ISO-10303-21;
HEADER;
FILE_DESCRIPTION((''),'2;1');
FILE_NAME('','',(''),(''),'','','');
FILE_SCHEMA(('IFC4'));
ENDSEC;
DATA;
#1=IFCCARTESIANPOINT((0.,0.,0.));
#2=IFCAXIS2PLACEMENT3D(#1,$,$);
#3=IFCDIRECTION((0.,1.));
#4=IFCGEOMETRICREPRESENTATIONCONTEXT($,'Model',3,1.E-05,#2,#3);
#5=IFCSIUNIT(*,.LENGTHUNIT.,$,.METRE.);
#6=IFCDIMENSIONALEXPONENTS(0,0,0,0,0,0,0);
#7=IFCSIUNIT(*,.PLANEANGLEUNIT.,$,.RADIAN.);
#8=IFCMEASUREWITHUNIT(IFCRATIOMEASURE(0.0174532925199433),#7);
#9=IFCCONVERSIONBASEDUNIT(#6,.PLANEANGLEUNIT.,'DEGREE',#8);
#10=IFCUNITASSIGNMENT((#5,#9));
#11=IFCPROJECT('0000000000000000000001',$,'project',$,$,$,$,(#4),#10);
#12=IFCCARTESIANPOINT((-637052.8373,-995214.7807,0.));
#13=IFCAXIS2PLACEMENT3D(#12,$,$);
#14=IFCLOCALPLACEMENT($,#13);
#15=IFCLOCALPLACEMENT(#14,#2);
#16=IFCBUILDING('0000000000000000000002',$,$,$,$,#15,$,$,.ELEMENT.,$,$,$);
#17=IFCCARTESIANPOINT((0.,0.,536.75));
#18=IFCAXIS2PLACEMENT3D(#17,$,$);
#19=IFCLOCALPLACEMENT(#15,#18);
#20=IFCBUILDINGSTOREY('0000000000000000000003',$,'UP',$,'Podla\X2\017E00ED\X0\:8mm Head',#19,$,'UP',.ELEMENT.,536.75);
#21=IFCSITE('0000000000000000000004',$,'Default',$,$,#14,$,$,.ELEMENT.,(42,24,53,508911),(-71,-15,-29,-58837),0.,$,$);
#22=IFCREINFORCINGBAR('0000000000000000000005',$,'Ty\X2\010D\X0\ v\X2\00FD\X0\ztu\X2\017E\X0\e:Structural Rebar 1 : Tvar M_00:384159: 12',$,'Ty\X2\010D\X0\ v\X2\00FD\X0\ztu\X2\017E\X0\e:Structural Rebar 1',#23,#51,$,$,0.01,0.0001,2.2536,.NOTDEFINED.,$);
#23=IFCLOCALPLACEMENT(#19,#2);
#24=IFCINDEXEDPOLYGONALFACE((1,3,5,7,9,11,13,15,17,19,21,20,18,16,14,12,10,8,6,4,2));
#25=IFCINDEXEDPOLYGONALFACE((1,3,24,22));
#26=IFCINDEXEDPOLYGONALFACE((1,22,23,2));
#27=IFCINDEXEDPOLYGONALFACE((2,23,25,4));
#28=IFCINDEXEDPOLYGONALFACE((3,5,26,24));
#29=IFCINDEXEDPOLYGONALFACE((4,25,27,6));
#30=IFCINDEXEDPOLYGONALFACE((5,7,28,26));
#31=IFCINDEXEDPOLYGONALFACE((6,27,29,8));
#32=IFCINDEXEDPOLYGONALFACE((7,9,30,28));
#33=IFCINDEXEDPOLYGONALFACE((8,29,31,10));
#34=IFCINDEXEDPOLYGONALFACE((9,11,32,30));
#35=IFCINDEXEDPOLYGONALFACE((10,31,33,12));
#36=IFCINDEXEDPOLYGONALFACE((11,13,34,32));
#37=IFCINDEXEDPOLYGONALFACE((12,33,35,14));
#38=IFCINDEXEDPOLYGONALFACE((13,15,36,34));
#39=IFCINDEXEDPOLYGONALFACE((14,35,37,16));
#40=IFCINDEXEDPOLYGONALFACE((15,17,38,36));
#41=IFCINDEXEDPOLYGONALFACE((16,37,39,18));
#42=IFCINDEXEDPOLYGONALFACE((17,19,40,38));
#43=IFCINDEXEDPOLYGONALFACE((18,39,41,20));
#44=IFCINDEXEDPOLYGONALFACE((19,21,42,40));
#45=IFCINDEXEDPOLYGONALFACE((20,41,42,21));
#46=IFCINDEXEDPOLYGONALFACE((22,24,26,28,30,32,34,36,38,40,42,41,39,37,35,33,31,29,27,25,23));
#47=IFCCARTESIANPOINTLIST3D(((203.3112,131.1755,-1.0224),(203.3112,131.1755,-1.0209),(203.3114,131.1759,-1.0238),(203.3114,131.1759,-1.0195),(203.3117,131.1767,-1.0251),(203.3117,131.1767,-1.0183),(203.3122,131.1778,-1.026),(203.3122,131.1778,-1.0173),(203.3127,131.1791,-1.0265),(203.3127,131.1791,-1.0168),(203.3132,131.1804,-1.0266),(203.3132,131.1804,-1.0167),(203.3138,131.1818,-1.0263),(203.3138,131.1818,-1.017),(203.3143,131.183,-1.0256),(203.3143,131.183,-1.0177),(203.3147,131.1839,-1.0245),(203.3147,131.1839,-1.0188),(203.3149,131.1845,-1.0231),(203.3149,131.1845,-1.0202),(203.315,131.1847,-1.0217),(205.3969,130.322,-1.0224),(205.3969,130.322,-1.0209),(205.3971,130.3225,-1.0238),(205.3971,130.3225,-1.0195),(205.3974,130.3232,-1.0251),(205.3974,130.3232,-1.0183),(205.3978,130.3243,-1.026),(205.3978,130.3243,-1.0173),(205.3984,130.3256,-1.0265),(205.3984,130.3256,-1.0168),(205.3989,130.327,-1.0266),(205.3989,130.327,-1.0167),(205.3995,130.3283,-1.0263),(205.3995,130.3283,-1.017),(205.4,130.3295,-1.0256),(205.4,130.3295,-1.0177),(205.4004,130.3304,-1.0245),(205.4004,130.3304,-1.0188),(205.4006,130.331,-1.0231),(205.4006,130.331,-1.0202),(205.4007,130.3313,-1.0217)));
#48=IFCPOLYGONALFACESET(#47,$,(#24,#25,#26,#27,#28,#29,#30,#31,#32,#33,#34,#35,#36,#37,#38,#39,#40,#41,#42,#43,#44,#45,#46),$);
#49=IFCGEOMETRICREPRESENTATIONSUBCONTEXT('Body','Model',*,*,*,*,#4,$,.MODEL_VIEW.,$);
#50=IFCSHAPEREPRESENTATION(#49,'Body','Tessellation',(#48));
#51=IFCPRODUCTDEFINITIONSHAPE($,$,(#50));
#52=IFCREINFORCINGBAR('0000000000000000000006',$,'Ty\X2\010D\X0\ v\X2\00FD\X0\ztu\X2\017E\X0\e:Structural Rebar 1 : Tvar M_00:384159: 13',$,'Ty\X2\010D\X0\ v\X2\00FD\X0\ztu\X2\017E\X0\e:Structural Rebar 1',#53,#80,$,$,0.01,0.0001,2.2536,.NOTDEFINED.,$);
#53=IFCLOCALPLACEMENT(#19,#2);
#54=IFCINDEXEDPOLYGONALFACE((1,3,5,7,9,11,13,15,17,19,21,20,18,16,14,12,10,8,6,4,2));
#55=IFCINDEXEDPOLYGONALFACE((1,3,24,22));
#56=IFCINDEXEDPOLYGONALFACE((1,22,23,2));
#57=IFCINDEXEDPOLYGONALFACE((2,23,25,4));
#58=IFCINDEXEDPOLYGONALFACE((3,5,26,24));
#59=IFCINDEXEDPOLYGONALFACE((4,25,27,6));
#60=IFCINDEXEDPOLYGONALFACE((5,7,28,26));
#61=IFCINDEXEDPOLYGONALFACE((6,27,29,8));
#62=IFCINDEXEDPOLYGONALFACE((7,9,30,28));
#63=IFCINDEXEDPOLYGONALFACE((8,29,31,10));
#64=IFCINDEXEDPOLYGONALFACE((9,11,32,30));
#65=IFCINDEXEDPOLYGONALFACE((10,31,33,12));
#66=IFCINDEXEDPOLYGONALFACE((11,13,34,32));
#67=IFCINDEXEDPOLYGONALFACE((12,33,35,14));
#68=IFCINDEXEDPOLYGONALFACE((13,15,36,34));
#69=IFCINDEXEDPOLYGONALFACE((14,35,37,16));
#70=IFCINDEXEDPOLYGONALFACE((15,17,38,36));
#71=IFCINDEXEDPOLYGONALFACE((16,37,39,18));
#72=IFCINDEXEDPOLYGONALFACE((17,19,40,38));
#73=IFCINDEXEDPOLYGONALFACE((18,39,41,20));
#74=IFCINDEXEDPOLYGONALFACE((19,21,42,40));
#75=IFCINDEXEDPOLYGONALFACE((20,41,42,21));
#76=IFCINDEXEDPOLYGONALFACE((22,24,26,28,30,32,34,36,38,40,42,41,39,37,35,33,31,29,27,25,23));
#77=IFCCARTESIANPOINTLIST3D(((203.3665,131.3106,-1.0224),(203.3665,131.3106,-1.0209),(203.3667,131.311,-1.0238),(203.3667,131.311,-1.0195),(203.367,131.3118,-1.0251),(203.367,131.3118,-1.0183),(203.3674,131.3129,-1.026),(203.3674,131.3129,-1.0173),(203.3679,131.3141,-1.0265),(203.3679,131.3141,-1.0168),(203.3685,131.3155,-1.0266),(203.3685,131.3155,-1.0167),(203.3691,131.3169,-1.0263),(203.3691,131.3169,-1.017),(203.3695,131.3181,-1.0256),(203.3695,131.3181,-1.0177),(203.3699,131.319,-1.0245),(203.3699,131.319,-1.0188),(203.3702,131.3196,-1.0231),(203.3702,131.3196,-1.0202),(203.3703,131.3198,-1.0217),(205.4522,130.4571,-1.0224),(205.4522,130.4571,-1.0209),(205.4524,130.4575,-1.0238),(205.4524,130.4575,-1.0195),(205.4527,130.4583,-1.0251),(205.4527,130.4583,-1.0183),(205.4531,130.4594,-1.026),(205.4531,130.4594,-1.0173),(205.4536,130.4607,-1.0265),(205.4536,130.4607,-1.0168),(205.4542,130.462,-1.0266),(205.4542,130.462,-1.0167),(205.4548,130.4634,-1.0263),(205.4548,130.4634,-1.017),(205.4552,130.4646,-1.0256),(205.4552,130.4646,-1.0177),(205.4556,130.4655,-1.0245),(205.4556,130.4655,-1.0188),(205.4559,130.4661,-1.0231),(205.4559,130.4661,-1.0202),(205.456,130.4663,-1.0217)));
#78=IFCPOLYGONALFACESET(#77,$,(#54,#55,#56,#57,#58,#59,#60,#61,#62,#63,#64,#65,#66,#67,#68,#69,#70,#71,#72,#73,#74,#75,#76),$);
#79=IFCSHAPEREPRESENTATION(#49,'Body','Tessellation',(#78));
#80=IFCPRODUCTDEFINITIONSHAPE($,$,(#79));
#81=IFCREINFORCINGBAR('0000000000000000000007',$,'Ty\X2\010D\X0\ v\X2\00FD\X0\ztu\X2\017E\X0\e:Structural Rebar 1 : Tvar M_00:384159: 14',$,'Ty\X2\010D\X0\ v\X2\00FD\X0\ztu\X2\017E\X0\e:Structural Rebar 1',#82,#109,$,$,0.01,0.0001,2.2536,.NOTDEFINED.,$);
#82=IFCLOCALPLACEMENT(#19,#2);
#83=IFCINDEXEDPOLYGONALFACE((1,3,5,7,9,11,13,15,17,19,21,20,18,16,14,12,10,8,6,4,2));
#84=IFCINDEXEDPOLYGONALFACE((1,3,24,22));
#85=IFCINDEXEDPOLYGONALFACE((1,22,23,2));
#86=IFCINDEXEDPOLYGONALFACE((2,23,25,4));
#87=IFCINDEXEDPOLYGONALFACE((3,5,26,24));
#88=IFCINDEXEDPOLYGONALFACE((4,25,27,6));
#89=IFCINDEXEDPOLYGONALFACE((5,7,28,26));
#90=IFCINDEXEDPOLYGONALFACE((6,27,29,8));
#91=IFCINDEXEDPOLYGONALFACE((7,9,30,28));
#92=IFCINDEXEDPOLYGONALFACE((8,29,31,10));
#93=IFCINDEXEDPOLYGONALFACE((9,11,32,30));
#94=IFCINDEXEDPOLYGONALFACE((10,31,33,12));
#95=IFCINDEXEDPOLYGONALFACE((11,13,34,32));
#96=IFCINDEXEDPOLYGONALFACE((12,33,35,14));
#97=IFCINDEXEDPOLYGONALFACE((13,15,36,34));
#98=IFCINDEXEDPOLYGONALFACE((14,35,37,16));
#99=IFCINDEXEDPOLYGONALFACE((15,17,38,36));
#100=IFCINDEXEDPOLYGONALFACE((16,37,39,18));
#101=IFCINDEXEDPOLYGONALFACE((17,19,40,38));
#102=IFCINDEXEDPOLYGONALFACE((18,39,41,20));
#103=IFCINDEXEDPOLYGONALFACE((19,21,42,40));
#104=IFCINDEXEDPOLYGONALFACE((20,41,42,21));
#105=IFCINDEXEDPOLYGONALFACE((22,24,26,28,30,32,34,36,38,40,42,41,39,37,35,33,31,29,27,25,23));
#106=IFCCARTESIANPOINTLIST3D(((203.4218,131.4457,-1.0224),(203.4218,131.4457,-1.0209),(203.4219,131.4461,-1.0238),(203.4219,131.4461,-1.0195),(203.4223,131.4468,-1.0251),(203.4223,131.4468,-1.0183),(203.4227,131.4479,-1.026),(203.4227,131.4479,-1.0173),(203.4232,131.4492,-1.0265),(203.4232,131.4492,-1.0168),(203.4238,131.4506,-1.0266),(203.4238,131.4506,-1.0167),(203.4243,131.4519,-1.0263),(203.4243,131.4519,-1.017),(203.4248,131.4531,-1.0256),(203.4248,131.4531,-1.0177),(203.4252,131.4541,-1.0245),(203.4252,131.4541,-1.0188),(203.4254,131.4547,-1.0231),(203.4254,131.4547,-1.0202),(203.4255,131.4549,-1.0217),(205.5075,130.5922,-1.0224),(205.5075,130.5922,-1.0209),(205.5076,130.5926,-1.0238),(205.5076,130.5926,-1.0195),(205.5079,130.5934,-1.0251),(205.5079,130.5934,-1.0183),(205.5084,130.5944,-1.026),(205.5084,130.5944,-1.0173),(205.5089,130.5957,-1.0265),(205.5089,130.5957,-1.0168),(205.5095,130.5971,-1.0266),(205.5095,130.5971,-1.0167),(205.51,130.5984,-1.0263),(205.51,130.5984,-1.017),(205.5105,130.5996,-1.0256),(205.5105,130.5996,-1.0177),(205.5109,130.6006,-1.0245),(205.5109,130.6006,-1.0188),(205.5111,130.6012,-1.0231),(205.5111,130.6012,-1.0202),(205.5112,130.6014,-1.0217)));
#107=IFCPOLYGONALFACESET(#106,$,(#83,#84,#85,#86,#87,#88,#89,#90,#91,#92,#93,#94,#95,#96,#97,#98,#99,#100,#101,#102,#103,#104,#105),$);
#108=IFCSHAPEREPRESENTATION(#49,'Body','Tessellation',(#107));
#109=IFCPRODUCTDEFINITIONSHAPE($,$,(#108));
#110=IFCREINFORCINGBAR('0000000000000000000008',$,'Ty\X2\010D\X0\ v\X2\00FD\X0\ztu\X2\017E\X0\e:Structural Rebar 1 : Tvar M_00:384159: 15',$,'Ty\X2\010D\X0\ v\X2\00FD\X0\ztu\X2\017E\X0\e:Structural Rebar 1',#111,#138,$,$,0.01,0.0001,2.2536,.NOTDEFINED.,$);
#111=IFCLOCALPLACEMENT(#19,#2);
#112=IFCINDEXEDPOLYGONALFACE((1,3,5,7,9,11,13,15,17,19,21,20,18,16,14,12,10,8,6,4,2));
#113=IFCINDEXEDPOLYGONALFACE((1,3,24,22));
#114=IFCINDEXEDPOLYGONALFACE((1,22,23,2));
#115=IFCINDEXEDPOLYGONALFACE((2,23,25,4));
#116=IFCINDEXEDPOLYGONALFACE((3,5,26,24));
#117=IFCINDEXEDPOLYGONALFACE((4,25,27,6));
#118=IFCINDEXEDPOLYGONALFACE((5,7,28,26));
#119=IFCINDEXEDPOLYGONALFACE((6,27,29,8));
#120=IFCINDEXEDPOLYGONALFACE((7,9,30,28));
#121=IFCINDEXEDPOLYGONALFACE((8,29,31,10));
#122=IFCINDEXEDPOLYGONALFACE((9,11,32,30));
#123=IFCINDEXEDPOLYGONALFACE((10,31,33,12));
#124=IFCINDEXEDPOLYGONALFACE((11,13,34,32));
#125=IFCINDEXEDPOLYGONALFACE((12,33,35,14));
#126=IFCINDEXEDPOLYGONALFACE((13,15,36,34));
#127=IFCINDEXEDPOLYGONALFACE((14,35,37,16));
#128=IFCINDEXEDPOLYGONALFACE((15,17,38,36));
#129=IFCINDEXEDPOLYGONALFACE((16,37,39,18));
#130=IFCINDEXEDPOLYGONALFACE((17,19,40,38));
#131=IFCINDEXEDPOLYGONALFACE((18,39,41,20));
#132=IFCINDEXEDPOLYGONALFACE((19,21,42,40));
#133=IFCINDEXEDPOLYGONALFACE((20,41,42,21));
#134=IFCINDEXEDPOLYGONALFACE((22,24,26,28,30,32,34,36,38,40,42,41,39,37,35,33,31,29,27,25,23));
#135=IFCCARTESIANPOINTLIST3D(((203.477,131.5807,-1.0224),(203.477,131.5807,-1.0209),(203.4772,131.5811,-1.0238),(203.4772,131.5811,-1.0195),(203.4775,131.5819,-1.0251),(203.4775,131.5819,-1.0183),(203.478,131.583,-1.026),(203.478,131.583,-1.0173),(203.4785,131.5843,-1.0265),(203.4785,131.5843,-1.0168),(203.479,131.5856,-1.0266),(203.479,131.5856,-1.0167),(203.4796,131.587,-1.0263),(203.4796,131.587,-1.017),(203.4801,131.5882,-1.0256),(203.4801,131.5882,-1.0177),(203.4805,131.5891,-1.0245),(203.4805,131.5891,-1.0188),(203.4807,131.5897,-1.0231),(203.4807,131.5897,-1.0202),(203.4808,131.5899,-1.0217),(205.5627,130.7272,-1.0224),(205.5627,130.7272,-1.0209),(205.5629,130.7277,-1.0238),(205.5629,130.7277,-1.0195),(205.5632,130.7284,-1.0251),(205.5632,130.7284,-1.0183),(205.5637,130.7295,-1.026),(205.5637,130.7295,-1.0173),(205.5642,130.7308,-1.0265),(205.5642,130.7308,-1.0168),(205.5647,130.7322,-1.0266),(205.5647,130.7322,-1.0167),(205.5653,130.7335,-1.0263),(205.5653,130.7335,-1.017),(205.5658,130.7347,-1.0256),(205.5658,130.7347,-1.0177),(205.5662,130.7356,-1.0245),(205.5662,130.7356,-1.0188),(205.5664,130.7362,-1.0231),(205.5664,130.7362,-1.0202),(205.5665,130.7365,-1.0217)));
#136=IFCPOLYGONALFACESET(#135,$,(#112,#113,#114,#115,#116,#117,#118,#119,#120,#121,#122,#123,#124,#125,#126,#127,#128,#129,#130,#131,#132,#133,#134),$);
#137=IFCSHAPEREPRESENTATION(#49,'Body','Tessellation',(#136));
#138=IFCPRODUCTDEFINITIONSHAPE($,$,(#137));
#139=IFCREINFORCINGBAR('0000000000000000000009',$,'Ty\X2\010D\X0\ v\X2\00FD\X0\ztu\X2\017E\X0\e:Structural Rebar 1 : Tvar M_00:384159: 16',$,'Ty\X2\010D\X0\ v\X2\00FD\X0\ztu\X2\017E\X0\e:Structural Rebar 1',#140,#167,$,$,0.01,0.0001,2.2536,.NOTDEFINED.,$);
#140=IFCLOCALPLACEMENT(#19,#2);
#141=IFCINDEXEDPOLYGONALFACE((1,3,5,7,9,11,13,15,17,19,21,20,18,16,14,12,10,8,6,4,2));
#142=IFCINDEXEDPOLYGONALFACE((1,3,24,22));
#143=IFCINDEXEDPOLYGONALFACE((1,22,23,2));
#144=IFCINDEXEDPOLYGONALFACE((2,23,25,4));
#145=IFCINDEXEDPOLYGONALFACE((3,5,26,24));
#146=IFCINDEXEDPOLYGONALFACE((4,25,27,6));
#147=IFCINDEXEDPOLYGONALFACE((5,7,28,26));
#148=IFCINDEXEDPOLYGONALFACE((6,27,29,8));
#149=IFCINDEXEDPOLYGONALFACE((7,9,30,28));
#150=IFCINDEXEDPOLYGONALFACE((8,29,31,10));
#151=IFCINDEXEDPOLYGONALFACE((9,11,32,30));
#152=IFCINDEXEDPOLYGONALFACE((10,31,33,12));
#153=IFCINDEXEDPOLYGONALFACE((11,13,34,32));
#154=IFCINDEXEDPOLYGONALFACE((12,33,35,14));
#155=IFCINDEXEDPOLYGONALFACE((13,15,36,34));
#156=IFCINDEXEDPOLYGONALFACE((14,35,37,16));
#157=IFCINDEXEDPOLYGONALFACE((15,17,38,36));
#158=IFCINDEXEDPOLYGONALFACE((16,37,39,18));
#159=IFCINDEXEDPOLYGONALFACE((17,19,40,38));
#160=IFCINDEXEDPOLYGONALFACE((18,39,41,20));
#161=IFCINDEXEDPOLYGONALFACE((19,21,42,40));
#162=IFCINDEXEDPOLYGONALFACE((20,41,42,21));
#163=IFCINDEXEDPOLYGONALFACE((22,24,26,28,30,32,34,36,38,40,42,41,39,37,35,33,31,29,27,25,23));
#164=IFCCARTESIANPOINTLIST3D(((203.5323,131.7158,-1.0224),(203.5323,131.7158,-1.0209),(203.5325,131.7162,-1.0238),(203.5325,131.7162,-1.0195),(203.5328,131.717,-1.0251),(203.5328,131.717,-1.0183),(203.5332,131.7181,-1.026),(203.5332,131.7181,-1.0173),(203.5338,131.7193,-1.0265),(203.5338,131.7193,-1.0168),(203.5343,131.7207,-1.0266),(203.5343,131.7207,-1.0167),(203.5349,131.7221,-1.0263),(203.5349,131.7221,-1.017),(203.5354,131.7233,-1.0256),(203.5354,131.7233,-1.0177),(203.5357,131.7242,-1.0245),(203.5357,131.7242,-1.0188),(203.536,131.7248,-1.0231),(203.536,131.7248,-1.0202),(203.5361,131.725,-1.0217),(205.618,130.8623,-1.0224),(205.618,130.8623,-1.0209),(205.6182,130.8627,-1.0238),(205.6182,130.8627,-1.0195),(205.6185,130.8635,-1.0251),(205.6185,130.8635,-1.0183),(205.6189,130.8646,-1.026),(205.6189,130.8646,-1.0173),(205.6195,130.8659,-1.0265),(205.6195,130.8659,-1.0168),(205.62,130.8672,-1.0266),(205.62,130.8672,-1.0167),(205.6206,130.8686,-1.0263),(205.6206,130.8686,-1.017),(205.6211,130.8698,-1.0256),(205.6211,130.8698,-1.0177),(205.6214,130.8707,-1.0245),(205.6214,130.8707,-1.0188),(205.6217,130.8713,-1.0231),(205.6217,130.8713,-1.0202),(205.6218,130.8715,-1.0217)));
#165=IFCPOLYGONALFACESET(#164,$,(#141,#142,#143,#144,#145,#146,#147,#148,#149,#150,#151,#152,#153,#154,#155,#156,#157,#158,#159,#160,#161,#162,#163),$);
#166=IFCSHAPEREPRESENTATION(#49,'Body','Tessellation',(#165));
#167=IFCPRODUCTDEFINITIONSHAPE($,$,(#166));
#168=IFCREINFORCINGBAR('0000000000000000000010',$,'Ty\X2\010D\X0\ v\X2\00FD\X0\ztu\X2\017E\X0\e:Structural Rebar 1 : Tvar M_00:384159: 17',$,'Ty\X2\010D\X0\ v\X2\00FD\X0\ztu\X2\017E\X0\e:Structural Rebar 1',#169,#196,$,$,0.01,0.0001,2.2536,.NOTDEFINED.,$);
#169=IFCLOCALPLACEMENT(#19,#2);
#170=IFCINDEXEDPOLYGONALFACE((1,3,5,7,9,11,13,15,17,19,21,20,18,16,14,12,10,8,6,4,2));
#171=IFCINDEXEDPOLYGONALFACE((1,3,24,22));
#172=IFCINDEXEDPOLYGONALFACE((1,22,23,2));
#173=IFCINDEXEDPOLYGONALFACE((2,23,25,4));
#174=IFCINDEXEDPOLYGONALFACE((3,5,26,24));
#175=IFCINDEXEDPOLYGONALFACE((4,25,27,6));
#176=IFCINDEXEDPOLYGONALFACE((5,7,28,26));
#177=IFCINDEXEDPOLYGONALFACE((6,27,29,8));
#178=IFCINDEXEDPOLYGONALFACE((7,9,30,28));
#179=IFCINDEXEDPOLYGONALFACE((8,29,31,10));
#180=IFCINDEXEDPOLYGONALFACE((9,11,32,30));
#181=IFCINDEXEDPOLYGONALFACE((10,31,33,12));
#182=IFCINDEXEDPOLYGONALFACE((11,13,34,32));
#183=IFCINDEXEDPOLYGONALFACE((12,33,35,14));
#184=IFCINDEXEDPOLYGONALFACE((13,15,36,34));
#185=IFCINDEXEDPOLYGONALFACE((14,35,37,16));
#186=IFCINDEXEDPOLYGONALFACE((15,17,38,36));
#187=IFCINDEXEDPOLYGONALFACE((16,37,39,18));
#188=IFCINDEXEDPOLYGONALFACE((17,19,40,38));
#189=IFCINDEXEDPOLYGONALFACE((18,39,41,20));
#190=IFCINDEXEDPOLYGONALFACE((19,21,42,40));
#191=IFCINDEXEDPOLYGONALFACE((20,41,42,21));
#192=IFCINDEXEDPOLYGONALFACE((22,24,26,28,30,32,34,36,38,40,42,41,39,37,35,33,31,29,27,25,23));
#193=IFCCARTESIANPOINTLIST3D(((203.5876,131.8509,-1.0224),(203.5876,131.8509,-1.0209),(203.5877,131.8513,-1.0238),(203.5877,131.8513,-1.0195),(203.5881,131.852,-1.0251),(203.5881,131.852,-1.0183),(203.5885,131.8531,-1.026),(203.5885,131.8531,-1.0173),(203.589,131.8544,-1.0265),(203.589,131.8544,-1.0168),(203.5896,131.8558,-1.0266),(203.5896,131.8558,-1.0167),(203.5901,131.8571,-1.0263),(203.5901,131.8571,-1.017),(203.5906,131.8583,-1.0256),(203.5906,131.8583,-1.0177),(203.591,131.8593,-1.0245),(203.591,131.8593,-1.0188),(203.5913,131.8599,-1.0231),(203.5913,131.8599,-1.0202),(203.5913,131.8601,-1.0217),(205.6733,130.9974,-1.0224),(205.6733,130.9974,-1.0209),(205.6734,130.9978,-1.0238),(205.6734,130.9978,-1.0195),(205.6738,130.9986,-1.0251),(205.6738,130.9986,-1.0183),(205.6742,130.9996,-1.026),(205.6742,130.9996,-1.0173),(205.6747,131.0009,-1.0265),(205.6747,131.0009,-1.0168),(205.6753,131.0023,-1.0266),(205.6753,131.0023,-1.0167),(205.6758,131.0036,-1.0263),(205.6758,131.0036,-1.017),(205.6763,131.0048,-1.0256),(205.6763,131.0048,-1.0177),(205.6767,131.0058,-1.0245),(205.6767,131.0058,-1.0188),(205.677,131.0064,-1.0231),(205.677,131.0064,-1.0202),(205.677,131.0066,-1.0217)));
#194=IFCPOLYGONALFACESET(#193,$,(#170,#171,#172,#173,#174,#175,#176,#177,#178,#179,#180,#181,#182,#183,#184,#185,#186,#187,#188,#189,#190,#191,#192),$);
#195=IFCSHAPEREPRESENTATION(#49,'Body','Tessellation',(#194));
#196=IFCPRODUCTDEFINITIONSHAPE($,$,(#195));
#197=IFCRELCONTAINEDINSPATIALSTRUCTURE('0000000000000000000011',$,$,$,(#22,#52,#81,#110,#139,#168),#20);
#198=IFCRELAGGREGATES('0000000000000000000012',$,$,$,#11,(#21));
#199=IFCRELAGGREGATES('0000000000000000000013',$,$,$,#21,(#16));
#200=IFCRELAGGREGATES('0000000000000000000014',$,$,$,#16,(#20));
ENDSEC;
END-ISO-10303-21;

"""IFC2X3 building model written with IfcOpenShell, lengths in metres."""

from ifc_helpers import new_model, entity, si_unit, converted_unit, direction, frame, origin, place, context, subcontext, project, spatial, element, save


model = new_model("IFC2X3")

# Units and contexts
model_context = context("Model", 3, precision=1e-05, world=origin(), true_north=direction((0.0, 1.0)))
body_context = subcontext(model_context, "Body", "Model", "MODEL_VIEW")
ifc_project = project(units=[si_unit("LENGTHUNIT", "METRE"), converted_unit("PLANEANGLEUNIT", "DEGREE", entity("IfcRatioMeasure", 0.0174532925199433), si_unit("PLANEANGLEUNIT", "RADIAN"), dimensions=[0, 0, 0, 0, 0, 0, 0])], contexts=[model_context])

# Site, building, storey
site_placement = place(None, frame((-637052.8373, -995214.7807, 0.0)))
site = spatial("IfcSite", under=ifc_project, at=site_placement, Name="Default", CompositionType="ELEMENT", RefLatitude=(42, 24, 53, 508911), RefLongitude=(-71, -15, -29, -58837), RefElevation=0.0)
building_placement = place(site_placement, origin())
building = spatial("IfcBuilding", under=site, at=building_placement, CompositionType="ELEMENT")
storey_placement = place(building_placement, frame((0.0, 0.0, 536.75)))
storey = spatial("IfcBuildingStorey", under=building, at=storey_placement, Name="UP", ObjectType="Podlaží:8mm Head", LongName="UP", CompositionType="ELEMENT", Elevation=536.75)

# Reinforcing bars
reinforcing_bar_1_placement = place(storey_placement, origin())
element("IfcReinforcingBar", 1, at=reinforcing_bar_1_placement, inside=storey, Name="Tyč výztuže:Structural Rebar 1 : Tvar M_00:384159: 12", ObjectType="Tyč výztuže:Structural Rebar 1", BarLength=2.2536, BarRole="NOTDEFINED", CrossSectionArea=0.0001, NominalDiameter=0.01, context=body_context, shape_type="AdvancedSweptSolid", body=[
    entity("IfcSweptDiskSolid", entity("IfcCompositeCurve", [entity("IfcCompositeCurveSegment", "CONTINUOUS", True, entity("IfcPolyline", [entity("IfcCartesianPoint", [-205.3988, -130.3266, 1.0217]), entity("IfcCartesianPoint", [-203.3131, -131.1801, 1.0217])]))], False), 0.005, None, 0.0, 1.0),
])
reinforcing_bar_2_placement = place(storey_placement, origin())
element("IfcReinforcingBar", 2, at=reinforcing_bar_2_placement, inside=storey, Name="Tyč výztuže:Structural Rebar 1 : Tvar M_00:384159: 13", ObjectType="Tyč výztuže:Structural Rebar 1", BarLength=2.2536, BarRole="NOTDEFINED", CrossSectionArea=0.0001, NominalDiameter=0.01, context=body_context, shape_type="AdvancedSweptSolid", body=[
    entity("IfcSweptDiskSolid", entity("IfcCompositeCurve", [entity("IfcCompositeCurveSegment", "CONTINUOUS", True, entity("IfcPolyline", [entity("IfcCartesianPoint", [-205.4541, -130.4617, 1.0217]), entity("IfcCartesianPoint", [-203.3684, -131.3152, 1.0217])]))], False), 0.005, None, 0.0, 1.0),
])
reinforcing_bar_3_placement = place(storey_placement, origin())
element("IfcReinforcingBar", 3, at=reinforcing_bar_3_placement, inside=storey, Name="Tyč výztuže:Structural Rebar 1 : Tvar M_00:384159: 14", ObjectType="Tyč výztuže:Structural Rebar 1", BarLength=2.2536, BarRole="NOTDEFINED", CrossSectionArea=0.0001, NominalDiameter=0.01, context=body_context, shape_type="AdvancedSweptSolid", body=[
    entity("IfcSweptDiskSolid", entity("IfcCompositeCurve", [entity("IfcCompositeCurveSegment", "CONTINUOUS", True, entity("IfcPolyline", [entity("IfcCartesianPoint", [-205.5093, -130.5968, 1.0217]), entity("IfcCartesianPoint", [-203.4236, -131.4502, 1.0217])]))], False), 0.005, None, 0.0, 1.0),
])
reinforcing_bar_4_placement = place(storey_placement, origin())
element("IfcReinforcingBar", 4, at=reinforcing_bar_4_placement, inside=storey, Name="Tyč výztuže:Structural Rebar 1 : Tvar M_00:384159: 15", ObjectType="Tyč výztuže:Structural Rebar 1", BarLength=2.2536, BarRole="NOTDEFINED", CrossSectionArea=0.0001, NominalDiameter=0.01, context=body_context, shape_type="AdvancedSweptSolid", body=[
    entity("IfcSweptDiskSolid", entity("IfcCompositeCurve", [entity("IfcCompositeCurveSegment", "CONTINUOUS", True, entity("IfcPolyline", [entity("IfcCartesianPoint", [-205.5646, -130.7318, 1.0217]), entity("IfcCartesianPoint", [-203.4789, -131.5853, 1.0217])]))], False), 0.005, None, 0.0, 1.0),
])
reinforcing_bar_5_placement = place(storey_placement, origin())
element("IfcReinforcingBar", 5, at=reinforcing_bar_5_placement, inside=storey, Name="Tyč výztuže:Structural Rebar 1 : Tvar M_00:384159: 16", ObjectType="Tyč výztuže:Structural Rebar 1", BarLength=2.2536, BarRole="NOTDEFINED", CrossSectionArea=0.0001, NominalDiameter=0.01, context=body_context, shape_type="AdvancedSweptSolid", body=[
    entity("IfcSweptDiskSolid", entity("IfcCompositeCurve", [entity("IfcCompositeCurveSegment", "CONTINUOUS", True, entity("IfcPolyline", [entity("IfcCartesianPoint", [-205.6199, -130.8669, 1.0217]), entity("IfcCartesianPoint", [-203.5342, -131.7204, 1.0217])]))], False), 0.005, None, 0.0, 1.0),
])
reinforcing_bar_6_placement = place(storey_placement, origin())
element("IfcReinforcingBar", 6, at=reinforcing_bar_6_placement, inside=storey, Name="Tyč výztuže:Structural Rebar 1 : Tvar M_00:384159: 17", ObjectType="Tyč výztuže:Structural Rebar 1", BarLength=2.2536, BarRole="NOTDEFINED", CrossSectionArea=0.0001, NominalDiameter=0.01, context=body_context, shape_type="AdvancedSweptSolid", body=[
    entity("IfcSweptDiskSolid", entity("IfcCompositeCurve", [entity("IfcCompositeCurveSegment", "CONTINUOUS", True, entity("IfcPolyline", [entity("IfcCartesianPoint", [-205.6751, -131.002, 1.0217]), entity("IfcCartesianPoint", [-203.5894, -131.8554, 1.0217])]))], False), 0.005, None, 0.0, 1.0),
])

save(model, "model.ifc")
